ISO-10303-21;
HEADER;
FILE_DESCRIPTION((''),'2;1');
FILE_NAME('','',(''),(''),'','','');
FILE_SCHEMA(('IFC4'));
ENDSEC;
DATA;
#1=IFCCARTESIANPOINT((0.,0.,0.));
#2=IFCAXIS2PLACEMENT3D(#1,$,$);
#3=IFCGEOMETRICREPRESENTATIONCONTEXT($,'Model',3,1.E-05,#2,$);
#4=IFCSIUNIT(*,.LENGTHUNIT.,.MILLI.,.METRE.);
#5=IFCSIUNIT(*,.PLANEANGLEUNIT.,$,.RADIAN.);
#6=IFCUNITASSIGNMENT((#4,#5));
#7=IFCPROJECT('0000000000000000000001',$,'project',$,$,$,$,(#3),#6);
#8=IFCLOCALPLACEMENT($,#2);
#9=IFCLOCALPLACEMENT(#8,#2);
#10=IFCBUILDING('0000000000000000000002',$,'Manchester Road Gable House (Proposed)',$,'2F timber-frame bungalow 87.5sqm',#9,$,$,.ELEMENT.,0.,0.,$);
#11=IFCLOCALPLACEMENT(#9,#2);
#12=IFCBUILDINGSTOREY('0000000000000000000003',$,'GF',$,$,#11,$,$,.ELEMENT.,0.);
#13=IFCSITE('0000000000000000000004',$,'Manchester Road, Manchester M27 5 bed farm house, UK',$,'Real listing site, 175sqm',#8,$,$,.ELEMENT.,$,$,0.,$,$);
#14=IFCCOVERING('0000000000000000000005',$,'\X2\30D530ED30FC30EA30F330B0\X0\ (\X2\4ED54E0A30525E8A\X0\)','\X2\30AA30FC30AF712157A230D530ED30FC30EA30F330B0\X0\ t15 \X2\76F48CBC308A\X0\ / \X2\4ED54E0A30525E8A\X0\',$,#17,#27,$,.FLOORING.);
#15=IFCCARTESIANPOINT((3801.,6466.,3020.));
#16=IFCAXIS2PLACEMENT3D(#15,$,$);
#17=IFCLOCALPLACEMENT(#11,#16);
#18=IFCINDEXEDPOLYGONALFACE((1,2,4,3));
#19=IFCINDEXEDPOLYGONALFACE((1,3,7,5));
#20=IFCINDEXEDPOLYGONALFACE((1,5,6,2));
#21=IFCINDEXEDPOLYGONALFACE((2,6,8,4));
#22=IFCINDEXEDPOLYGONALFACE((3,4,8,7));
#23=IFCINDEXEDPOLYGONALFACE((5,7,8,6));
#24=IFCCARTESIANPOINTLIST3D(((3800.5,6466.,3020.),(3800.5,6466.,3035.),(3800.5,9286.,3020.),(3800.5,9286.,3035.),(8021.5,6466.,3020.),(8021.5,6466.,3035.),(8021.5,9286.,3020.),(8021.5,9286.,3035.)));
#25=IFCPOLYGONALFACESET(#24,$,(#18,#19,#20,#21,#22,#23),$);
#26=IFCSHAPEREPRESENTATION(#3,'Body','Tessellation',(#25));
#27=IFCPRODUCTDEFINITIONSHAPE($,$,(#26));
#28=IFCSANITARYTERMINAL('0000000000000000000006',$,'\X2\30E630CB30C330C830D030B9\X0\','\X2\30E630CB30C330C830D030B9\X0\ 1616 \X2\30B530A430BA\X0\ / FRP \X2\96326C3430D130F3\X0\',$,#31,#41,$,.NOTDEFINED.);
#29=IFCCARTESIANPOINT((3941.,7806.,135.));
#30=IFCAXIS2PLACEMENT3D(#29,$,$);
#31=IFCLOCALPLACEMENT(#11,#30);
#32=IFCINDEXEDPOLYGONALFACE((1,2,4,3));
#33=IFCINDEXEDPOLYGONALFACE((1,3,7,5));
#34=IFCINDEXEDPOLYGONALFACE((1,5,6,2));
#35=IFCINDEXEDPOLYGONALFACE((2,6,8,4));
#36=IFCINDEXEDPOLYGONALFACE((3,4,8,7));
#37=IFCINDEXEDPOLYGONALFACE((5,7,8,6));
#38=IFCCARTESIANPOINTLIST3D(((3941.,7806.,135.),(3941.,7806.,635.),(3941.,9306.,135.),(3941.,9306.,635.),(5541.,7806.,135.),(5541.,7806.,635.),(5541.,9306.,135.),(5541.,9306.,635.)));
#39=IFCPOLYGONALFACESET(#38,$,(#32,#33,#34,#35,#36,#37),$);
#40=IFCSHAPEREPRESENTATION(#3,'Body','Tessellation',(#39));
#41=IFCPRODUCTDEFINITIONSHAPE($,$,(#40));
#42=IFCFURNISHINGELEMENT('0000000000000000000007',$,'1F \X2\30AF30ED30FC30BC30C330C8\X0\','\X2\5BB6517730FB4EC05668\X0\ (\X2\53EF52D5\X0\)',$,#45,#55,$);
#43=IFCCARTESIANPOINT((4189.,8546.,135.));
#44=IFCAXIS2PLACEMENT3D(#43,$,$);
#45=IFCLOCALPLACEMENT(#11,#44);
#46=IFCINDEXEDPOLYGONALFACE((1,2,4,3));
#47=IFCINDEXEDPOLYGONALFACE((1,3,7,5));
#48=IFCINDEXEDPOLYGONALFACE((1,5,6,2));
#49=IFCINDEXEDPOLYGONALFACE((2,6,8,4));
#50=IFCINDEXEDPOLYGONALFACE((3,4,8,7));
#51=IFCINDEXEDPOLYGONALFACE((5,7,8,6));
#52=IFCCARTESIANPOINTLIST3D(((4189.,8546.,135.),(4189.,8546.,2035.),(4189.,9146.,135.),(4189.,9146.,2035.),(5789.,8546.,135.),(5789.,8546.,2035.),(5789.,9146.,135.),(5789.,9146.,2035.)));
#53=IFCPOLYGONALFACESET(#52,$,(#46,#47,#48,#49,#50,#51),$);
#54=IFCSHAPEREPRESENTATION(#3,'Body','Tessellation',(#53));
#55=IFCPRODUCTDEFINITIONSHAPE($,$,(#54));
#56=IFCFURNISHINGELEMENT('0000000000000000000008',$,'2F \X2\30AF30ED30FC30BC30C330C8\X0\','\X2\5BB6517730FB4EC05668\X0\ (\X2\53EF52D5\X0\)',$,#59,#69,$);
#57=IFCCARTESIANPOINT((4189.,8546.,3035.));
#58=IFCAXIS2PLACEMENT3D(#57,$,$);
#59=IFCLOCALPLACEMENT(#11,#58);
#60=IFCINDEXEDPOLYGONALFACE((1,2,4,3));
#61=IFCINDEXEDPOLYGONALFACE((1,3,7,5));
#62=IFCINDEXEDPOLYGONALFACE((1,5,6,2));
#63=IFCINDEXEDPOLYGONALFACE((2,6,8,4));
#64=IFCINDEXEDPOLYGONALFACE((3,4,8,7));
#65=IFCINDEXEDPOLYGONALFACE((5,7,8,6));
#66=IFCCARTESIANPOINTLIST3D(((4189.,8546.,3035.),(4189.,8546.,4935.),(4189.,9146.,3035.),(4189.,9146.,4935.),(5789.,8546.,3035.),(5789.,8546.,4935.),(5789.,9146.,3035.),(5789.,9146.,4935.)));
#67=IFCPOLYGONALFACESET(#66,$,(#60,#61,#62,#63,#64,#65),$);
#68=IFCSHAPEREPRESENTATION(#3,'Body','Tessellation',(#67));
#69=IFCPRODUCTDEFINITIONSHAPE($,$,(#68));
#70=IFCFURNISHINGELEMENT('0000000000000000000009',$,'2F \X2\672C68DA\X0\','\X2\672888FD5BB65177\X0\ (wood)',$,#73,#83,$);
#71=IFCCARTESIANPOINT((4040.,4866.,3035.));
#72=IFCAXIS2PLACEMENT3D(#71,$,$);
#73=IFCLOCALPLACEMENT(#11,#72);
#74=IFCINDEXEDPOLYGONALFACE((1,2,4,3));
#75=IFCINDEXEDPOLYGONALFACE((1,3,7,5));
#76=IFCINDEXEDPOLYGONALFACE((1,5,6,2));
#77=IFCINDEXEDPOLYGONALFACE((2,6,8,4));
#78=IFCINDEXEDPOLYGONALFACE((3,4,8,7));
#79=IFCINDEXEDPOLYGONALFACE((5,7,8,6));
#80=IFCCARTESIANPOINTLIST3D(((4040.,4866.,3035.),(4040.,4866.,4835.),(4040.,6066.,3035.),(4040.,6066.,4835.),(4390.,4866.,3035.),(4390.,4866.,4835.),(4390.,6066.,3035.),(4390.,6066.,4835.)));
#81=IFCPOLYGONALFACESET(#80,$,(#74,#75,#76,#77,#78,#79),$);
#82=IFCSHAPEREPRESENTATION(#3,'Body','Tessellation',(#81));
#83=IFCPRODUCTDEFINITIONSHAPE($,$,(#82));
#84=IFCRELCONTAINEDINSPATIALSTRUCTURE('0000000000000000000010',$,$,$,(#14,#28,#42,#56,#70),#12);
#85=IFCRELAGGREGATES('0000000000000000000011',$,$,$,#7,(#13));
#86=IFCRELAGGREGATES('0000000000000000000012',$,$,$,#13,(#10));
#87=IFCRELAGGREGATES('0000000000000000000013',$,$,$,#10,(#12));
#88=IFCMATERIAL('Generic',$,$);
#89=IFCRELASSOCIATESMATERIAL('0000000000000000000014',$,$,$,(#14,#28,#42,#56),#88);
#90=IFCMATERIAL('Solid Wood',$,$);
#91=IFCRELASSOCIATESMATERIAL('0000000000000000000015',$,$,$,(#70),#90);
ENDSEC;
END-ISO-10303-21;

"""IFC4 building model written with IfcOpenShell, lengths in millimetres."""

from ifc_helpers import new_model, si_unit, frame, frame_2d, origin, place, context, project, spatial, rectangle, extrude, material, element, save


model = new_model("IFC4")

# Units and contexts
model_context = context("Model", 3, precision=1e-05, world=origin())
ifc_project = project(units=[si_unit("LENGTHUNIT", "METRE", prefix="MILLI"), si_unit("PLANEANGLEUNIT", "RADIAN")], contexts=[model_context])

# Site, building, storey
site_placement = place(None, origin())
site = spatial("IfcSite", under=ifc_project, at=site_placement, Name="Manchester Road, Manchester M27 5 bed farm house, UK", ObjectType="Real listing site, 175sqm", CompositionType="ELEMENT", RefElevation=0.0)
building_placement = place(site_placement, origin())
building = spatial("IfcBuilding", under=site, at=building_placement, Name="Manchester Road Gable House (Proposed)", ObjectType="2F timber-frame bungalow 87.5sqm", CompositionType="ELEMENT", ElevationOfRefHeight=0.0, ElevationOfTerrain=0.0)
storey_placement = place(building_placement, origin())
storey = spatial("IfcBuildingStorey", under=building, at=storey_placement, Name="GF", CompositionType="ELEMENT", Elevation=0.0)

# Shared definitions
ifc_material_1 = material(Name="Solid Wood")

# Covering
ifc_material_2 = material(Name="Generic")
covering_1_placement = place(storey_placement, frame((3801.0, 6466.0, 3020.0)))
element("IfcCovering", 1, at=covering_1_placement, inside=storey, material=ifc_material_2, Name="フローリング (仕上げ床)", Description="オーク無垢フローリング t15 直貼り / 仕上げ床", PredefinedType="FLOORING", context=model_context, shape_type="SweptSolid", body=[
    extrude(rectangle(XDim=4221.0, YDim=2820.0, at=frame_2d((2110.0, 1410.0))), frame((3801.0, 6466.0, 3020.0)), (0.0, 0.0, 1.0), 15.0),
])

# Sanitary terminal
sanitary_terminal_placement = place(storey_placement, frame((3941.0, 7806.0, 135.0)))
element("IfcSanitaryTerminal", 2, at=sanitary_terminal_placement, inside=storey, material=ifc_material_2, Name="ユニットバス", Description="ユニットバス 1616 サイズ / FRP 防水パン", PredefinedType="NOTDEFINED", context=model_context, shape_type="SweptSolid", body=[
    extrude(rectangle(XDim=1600.0, YDim=1500.0, at=frame_2d((800.0, 750.0))), frame((3941.0, 7806.0, 135.0)), (0.0, 0.0, 1.0), 500.0),
])

# Furnishing elements
furnishing_1_placement = place(storey_placement, frame((4189.0, 8546.0, 135.0)))
element("IfcFurnishingElement", 3, at=furnishing_1_placement, inside=storey, material=ifc_material_2, Name="1F クローゼット", Description="家具・什器 (可動)", context=model_context, shape_type="SweptSolid", body=[
    extrude(rectangle(XDim=1600.0, YDim=600.0, at=frame_2d((800.0, 300.0))), frame((4189.0, 8546.0, 135.0)), (0.0, 0.0, 1.0), 1900.0),
])
furnishing_2_placement = place(storey_placement, frame((4189.0, 8546.0, 3035.0)))
element("IfcFurnishingElement", 4, at=furnishing_2_placement, inside=storey, material=ifc_material_2, Name="2F クローゼット", Description="家具・什器 (可動)", context=model_context, shape_type="SweptSolid", body=[
    extrude(rectangle(XDim=1600.0, YDim=600.0, at=frame_2d((800.0, 300.0))), frame((4189.0, 8546.0, 3035.0)), (0.0, 0.0, 1.0), 1900.0),
])
furnishing_3_placement = place(storey_placement, frame((4040.0, 4866.0, 3035.0)))
element("IfcFurnishingElement", 5, at=furnishing_3_placement, inside=storey, material=ifc_material_1, Name="2F 本棚", Description="木製家具 (wood)", context=model_context, shape_type="SweptSolid", body=[
    extrude(rectangle(XDim=350.0, YDim=1200.0, at=frame_2d((175.0, 600.0))), frame((4040.0, 4866.0, 3035.0)), (0.0, 0.0, 1.0), 1800.0),
])

save(model, "model.ifc")
